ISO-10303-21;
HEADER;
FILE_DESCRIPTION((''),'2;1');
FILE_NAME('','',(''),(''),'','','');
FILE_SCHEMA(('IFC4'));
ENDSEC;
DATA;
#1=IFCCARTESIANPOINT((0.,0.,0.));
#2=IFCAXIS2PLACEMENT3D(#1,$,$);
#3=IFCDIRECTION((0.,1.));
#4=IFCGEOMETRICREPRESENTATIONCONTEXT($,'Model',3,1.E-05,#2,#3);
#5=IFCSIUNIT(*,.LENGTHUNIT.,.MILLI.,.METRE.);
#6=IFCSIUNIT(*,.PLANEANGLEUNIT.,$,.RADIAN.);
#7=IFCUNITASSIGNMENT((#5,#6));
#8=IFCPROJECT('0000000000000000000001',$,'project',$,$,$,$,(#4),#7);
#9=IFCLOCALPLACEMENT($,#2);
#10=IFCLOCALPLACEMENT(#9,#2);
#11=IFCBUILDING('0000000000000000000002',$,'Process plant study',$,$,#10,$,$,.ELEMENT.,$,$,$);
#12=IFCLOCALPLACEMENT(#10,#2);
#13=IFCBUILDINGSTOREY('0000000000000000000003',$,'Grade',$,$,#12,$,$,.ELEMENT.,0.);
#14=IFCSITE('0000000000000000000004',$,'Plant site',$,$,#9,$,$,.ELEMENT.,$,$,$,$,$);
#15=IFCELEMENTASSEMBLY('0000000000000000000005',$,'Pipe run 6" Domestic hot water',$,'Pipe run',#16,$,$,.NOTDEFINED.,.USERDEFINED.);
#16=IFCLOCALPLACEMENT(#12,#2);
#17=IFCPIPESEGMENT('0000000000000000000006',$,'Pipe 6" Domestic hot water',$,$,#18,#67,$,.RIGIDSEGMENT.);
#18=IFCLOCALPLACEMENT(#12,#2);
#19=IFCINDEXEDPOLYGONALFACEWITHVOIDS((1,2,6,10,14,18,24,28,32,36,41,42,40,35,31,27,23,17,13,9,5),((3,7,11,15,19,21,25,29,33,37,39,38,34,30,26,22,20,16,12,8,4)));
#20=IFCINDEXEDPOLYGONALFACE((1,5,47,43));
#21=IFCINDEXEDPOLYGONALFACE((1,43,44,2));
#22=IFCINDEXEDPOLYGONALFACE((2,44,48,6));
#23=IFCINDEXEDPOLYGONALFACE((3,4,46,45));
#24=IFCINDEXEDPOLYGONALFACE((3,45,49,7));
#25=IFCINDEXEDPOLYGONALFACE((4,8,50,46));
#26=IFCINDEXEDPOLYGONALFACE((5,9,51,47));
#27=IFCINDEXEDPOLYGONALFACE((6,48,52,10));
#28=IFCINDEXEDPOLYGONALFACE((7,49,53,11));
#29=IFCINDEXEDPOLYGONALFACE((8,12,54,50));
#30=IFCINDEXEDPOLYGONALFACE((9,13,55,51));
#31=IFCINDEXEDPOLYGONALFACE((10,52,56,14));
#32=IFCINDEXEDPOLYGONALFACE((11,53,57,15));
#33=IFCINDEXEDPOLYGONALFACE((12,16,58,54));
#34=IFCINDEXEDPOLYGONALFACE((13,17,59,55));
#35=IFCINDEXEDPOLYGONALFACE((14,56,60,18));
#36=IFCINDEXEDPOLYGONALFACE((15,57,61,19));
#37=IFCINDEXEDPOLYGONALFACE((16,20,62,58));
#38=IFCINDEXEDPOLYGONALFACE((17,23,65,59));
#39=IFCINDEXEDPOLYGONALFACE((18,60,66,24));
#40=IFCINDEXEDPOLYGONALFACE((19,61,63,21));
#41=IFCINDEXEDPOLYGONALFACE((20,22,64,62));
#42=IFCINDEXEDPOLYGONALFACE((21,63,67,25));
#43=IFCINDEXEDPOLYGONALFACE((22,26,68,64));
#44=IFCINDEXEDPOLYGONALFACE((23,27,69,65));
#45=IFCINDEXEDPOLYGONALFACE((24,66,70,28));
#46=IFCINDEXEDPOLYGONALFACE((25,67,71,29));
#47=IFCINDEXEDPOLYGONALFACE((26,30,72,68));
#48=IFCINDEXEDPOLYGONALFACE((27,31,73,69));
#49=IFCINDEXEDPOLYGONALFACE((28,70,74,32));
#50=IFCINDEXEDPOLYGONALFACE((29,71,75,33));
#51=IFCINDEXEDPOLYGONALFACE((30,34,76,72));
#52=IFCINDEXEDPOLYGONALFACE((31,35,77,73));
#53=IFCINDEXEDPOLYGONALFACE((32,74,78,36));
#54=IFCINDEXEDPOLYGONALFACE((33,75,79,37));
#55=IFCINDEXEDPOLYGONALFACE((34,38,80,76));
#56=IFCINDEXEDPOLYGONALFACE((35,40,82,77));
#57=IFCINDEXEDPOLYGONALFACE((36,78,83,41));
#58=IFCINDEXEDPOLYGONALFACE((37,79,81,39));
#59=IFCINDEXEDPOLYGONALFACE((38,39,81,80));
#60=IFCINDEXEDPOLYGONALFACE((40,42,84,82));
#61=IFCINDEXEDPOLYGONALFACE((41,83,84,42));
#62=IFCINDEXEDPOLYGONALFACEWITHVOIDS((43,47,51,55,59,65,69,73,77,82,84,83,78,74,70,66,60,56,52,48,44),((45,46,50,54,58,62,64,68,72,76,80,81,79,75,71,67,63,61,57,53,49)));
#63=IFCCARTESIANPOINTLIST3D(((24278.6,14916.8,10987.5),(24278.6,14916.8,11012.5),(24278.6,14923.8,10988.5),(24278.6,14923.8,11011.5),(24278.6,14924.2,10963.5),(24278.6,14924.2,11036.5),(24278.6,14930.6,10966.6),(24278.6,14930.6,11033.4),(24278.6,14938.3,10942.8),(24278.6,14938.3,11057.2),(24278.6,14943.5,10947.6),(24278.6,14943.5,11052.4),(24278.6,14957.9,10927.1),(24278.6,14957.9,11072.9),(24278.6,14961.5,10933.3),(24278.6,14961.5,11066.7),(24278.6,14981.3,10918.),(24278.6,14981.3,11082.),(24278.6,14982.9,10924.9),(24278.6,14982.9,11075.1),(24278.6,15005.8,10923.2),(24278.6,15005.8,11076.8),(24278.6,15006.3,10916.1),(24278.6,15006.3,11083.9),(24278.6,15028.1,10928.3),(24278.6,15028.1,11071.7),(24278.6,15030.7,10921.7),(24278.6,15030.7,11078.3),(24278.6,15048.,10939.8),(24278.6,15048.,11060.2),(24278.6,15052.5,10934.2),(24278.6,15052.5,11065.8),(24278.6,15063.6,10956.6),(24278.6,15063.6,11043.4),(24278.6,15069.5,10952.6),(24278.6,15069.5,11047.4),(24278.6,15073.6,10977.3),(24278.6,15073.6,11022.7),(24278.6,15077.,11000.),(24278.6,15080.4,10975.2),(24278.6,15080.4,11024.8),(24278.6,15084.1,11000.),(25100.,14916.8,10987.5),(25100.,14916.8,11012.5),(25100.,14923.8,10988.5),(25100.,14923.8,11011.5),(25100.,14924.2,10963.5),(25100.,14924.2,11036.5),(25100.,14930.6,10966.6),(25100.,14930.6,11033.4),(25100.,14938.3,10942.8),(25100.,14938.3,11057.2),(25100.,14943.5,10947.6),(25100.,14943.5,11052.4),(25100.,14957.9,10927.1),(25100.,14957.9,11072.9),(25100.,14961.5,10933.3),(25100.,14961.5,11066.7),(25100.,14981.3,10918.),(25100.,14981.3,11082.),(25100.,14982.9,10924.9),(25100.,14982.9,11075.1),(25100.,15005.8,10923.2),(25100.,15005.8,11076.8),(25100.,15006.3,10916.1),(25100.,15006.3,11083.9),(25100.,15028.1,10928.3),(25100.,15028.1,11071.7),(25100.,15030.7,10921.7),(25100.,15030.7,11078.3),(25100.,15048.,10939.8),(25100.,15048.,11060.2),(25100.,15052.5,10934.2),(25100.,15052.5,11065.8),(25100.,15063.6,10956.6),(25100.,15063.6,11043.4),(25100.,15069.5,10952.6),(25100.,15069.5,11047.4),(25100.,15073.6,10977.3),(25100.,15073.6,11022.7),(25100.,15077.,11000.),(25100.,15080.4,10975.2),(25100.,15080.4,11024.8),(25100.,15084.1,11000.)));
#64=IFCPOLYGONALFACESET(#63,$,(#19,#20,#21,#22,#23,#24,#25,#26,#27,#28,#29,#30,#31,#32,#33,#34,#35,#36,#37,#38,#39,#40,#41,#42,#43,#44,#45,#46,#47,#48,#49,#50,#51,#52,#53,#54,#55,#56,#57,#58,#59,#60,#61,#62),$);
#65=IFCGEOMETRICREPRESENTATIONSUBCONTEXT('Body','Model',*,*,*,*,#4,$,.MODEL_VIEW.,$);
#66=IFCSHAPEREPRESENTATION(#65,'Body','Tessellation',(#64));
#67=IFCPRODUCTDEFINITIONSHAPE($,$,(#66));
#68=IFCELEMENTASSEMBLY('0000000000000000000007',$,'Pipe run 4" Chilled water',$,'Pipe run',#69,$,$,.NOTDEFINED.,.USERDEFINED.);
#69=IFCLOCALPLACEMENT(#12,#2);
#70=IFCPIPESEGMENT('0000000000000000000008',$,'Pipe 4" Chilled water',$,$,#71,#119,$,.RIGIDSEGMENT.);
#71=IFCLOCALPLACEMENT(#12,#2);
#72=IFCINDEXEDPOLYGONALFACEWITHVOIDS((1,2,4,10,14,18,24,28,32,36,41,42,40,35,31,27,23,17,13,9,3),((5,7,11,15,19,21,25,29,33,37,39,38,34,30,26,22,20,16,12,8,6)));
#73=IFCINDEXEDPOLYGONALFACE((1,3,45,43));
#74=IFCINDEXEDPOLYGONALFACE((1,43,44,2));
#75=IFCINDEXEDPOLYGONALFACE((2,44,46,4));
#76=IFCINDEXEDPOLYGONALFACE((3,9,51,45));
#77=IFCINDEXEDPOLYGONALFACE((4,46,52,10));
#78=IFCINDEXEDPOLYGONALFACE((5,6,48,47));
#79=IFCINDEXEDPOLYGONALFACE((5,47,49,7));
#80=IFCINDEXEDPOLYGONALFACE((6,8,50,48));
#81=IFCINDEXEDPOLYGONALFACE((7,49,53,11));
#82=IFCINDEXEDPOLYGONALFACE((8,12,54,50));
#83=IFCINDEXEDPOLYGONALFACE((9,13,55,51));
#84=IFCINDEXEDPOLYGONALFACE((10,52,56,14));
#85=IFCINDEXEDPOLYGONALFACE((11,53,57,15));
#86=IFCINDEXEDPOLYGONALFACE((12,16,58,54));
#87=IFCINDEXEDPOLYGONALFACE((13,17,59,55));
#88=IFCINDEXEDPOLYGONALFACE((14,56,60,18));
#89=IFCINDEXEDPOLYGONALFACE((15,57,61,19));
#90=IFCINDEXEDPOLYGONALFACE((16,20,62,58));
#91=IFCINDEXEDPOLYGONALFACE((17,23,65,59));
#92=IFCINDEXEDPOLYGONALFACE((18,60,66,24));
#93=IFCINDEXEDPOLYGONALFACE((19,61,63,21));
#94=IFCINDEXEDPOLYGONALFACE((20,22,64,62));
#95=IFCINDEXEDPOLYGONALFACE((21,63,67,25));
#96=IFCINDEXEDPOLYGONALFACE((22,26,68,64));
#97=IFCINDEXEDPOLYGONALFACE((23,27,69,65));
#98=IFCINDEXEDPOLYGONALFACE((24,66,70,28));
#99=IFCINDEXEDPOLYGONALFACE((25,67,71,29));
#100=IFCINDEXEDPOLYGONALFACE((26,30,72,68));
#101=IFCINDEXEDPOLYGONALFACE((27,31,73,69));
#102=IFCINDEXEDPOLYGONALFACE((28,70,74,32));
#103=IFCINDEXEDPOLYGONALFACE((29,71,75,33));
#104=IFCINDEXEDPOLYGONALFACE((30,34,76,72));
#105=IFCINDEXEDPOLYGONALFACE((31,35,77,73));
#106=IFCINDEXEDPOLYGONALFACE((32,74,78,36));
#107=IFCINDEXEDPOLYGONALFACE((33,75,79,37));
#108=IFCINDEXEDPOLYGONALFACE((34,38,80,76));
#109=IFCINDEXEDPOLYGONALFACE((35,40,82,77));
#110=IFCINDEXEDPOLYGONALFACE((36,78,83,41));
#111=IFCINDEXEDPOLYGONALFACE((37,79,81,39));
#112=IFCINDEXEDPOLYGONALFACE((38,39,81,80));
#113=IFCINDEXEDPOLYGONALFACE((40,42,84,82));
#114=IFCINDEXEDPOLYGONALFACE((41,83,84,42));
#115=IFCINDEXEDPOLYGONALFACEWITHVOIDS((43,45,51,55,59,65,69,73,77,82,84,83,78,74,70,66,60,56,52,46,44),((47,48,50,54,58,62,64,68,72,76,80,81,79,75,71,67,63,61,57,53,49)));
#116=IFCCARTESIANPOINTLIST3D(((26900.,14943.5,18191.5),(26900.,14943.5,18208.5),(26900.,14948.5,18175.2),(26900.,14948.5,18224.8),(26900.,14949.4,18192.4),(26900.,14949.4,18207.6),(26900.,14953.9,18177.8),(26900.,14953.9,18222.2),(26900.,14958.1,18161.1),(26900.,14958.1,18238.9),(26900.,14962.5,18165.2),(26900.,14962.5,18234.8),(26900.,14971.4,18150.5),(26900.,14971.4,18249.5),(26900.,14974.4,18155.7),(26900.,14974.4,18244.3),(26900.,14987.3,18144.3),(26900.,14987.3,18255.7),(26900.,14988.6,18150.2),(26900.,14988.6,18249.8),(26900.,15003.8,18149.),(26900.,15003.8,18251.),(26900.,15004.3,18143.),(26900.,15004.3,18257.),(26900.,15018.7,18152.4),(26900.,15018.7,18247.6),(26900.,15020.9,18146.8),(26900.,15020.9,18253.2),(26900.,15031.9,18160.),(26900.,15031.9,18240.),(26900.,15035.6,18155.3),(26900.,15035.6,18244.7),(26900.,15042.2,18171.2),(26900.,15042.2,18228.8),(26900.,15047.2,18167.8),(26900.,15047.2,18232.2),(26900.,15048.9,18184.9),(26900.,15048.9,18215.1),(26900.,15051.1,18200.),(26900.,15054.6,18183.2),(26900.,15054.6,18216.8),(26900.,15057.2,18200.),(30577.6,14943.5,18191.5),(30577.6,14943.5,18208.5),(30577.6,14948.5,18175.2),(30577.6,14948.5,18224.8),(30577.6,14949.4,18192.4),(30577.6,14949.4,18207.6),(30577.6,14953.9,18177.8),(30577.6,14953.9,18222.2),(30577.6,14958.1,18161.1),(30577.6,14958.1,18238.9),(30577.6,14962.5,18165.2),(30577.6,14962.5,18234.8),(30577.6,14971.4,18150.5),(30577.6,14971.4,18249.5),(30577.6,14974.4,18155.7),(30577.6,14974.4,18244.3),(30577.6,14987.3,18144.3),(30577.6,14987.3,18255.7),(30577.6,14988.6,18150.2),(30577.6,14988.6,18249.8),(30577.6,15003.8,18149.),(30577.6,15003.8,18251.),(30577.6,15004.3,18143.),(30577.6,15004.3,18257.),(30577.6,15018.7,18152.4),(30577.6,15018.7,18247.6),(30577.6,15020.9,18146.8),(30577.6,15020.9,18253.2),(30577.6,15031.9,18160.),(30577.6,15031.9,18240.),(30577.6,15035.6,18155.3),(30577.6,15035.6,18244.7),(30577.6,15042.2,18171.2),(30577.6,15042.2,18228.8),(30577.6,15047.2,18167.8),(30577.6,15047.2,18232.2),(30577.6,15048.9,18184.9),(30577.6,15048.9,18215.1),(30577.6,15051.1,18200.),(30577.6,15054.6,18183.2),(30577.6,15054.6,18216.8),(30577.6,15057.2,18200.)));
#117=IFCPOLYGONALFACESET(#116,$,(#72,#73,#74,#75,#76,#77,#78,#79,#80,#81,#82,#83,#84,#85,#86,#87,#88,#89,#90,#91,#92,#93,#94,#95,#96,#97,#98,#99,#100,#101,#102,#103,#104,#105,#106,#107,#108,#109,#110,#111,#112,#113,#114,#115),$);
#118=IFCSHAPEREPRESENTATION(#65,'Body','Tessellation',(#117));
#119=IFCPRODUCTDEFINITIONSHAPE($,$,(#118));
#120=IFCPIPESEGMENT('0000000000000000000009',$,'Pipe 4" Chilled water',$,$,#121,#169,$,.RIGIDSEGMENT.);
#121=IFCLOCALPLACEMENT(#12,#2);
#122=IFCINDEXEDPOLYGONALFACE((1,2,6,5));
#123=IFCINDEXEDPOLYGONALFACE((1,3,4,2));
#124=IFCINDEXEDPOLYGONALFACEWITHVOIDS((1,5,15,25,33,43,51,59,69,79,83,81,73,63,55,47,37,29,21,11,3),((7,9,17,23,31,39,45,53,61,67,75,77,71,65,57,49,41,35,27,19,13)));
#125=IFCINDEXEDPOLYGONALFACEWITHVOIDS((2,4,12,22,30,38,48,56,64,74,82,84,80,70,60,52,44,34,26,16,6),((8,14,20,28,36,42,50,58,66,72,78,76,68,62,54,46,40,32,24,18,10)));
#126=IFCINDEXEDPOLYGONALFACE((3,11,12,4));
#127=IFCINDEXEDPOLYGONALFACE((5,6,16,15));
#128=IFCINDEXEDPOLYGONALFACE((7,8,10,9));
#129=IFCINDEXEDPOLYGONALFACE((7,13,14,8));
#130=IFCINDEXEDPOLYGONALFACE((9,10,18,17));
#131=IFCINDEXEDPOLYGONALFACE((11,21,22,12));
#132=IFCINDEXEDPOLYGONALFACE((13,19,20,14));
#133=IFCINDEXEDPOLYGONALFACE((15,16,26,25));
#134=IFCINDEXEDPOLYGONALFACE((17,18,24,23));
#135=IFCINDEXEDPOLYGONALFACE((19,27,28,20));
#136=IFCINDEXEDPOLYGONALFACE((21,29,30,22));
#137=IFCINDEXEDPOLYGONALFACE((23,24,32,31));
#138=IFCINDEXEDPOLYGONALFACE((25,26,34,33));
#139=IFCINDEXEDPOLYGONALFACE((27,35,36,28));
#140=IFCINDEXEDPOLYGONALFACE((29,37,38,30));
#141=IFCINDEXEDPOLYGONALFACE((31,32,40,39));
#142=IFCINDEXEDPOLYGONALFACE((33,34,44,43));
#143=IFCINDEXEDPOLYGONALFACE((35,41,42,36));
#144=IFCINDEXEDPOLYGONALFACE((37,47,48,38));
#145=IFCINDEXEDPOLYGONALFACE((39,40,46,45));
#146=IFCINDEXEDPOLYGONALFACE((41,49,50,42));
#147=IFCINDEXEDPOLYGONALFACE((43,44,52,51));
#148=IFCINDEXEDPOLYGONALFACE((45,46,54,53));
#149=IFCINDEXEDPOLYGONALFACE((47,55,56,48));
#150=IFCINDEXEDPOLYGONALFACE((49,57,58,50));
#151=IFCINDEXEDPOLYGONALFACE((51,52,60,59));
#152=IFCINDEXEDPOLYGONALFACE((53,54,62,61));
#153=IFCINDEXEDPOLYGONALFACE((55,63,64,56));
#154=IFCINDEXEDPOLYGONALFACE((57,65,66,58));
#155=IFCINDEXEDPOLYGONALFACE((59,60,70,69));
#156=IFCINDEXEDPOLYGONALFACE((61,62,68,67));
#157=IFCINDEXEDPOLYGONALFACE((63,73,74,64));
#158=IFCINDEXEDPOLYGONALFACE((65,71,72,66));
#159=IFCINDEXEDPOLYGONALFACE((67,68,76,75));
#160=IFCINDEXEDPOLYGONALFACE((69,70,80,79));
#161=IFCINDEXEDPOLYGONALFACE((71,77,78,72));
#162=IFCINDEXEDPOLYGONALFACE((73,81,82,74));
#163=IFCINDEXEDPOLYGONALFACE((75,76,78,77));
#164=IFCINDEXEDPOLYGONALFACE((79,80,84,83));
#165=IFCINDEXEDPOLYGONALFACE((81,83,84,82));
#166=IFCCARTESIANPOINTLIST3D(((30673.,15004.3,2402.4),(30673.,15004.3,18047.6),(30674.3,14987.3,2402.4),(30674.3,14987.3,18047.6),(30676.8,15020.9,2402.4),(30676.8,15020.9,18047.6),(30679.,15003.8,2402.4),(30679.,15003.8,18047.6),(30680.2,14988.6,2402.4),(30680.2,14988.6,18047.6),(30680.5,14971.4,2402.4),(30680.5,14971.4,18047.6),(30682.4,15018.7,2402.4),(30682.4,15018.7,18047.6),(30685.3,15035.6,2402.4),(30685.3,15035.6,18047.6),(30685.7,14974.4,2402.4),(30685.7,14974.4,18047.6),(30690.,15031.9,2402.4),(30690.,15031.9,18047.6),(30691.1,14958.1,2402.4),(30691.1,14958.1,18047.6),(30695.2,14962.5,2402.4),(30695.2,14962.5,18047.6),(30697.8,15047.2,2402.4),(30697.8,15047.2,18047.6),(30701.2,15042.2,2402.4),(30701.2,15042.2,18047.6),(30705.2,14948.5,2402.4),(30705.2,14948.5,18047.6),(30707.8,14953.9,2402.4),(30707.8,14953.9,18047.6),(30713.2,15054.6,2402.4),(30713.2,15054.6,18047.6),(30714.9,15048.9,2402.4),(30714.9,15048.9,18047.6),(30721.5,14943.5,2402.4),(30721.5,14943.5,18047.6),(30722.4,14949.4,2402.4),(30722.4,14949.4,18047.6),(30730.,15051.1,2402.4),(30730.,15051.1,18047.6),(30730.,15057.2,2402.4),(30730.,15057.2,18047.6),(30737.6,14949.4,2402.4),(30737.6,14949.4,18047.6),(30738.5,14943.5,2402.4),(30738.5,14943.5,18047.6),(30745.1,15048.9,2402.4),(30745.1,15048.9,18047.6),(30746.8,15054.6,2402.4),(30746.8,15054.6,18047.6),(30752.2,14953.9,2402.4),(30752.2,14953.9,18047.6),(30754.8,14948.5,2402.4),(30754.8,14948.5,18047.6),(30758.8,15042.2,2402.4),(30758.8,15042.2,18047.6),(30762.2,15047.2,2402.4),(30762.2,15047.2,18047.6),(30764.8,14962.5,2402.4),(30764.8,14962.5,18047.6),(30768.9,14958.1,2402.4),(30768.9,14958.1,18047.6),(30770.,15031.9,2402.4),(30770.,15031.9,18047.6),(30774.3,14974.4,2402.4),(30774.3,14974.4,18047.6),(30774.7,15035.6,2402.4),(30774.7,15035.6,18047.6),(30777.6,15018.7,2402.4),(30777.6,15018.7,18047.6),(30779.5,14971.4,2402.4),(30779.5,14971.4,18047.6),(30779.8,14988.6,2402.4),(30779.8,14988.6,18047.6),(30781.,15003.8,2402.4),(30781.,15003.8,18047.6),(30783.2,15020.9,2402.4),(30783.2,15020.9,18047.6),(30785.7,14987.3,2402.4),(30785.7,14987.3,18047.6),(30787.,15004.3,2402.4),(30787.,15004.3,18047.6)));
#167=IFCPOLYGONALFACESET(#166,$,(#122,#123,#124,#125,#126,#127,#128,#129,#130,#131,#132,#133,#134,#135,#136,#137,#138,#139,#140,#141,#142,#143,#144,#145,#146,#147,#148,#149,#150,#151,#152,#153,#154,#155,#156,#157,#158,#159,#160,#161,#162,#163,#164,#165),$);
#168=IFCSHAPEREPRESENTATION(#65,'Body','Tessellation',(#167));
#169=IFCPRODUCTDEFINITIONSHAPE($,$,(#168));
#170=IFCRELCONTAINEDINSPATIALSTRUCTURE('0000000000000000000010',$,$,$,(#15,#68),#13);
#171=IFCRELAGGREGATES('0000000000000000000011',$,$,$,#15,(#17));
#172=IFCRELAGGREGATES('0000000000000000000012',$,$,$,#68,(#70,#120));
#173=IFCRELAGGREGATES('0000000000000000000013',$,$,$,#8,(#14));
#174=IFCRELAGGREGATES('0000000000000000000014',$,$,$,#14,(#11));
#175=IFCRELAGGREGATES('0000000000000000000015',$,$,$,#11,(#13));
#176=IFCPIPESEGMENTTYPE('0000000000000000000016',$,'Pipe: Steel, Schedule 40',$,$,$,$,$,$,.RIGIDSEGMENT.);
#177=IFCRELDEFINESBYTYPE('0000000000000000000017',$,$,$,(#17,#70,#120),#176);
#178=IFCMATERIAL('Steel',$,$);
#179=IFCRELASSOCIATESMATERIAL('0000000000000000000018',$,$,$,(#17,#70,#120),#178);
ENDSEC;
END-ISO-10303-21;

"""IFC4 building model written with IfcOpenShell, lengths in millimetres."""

from ifc_helpers import new_model, si_unit, direction, frame, origin, origin_with_axes, origin_2d, place, context, subcontext, project, spatial, hollow_circle, extrude, material, type_object, element, aggregate, save


model = new_model("IFC4")

# Units and contexts
model_context = context("Model", 3, precision=1e-05, world=origin(), true_north=direction((0.0, 1.0)))
body_context = subcontext(model_context, "Body", "Model", "MODEL_VIEW")
ifc_project = project(units=[si_unit("LENGTHUNIT", "METRE", prefix="MILLI"), si_unit("PLANEANGLEUNIT", "RADIAN")], contexts=[model_context])

# Site, building, storey
site_placement = place(None, origin())
site = spatial("IfcSite", under=ifc_project, at=site_placement, Name="Plant site", CompositionType="ELEMENT")
building_placement = place(site_placement, origin())
building = spatial("IfcBuilding", under=site, at=building_placement, Name="Process plant study", CompositionType="ELEMENT")
storey_placement = place(building_placement, origin())
storey = spatial("IfcBuildingStorey", under=building, at=storey_placement, Name="Grade", CompositionType="ELEMENT", Elevation=0.0)

# Element assembly, pipe segment
assembly_1_placement = place(storey_placement, origin_with_axes())
assembly_1 = element("IfcElementAssembly", 1, at=assembly_1_placement, inside=storey, Name="Pipe run 6\" Domestic hot water", ObjectType="Pipe run", AssemblyPlace="NOTDEFINED", PredefinedType="USERDEFINED")
ifc_material = material(Name="Steel")
pipe_segment_type = type_object("IfcPipeSegmentType", Name="Pipe: Steel, Schedule 40", PredefinedType="RIGIDSEGMENT")
pipe_segment_1_placement = place(storey_placement, origin_with_axes())
pipe_segment_1 = element("IfcPipeSegment", 2, at=pipe_segment_1_placement, type_object=pipe_segment_type, material=ifc_material, Name="Pipe 6\" Domestic hot water", PredefinedType="RIGIDSEGMENT", context=body_context, shape_type="SweptSolid", body=[
    extrude(hollow_circle(Radius=84.1, WallThickness=7.1, at=origin_2d()), frame((24278.6, 15000.0, 11000.0), z_axis=(1.0, 0.0, 0.0), x_axis=(0.0, 1.0, 0.0)), (0.0, 0.0, 1.0), 821.4),
])

# Element assembly, pipe segments
assembly_2_placement = place(storey_placement, origin_with_axes())
assembly_2 = element("IfcElementAssembly", 3, at=assembly_2_placement, inside=storey, Name="Pipe run 4\" Chilled water", ObjectType="Pipe run", AssemblyPlace="NOTDEFINED", PredefinedType="USERDEFINED")
pipe_segment_2_placement = place(storey_placement, origin_with_axes())
pipe_segment_2 = element("IfcPipeSegment", 4, at=pipe_segment_2_placement, type_object=pipe_segment_type, material=ifc_material, Name="Pipe 4\" Chilled water", PredefinedType="RIGIDSEGMENT", context=body_context, shape_type="SweptSolid", body=[
    extrude(hollow_circle(Radius=57.1, WallThickness=6.0, at=origin_2d()), frame((26900.0, 15000.0, 18200.0), z_axis=(1.0, 0.0, 0.0), x_axis=(0.0, 1.0, 0.0)), (0.0, 0.0, 1.0), 3677.6),
])
pipe_segment_3_placement = place(storey_placement, origin_with_axes())
pipe_segment_3 = element("IfcPipeSegment", 5, at=pipe_segment_3_placement, type_object=pipe_segment_type, material=ifc_material, Name="Pipe 4\" Chilled water", PredefinedType="RIGIDSEGMENT", context=body_context, shape_type="SweptSolid", body=[
    extrude(hollow_circle(Radius=57.1, WallThickness=6.0, at=origin_2d()), frame((30730.0, 15000.0, 18047.6), z_axis=(0.0, 0.0, -1.0), x_axis=(0.0, 1.0, 0.0)), (0.0, 0.0, 1.0), 15645.2),
])

aggregate(assembly_1, [pipe_segment_1])
aggregate(assembly_2, [pipe_segment_2, pipe_segment_3])

save(model, "model.ifc")
